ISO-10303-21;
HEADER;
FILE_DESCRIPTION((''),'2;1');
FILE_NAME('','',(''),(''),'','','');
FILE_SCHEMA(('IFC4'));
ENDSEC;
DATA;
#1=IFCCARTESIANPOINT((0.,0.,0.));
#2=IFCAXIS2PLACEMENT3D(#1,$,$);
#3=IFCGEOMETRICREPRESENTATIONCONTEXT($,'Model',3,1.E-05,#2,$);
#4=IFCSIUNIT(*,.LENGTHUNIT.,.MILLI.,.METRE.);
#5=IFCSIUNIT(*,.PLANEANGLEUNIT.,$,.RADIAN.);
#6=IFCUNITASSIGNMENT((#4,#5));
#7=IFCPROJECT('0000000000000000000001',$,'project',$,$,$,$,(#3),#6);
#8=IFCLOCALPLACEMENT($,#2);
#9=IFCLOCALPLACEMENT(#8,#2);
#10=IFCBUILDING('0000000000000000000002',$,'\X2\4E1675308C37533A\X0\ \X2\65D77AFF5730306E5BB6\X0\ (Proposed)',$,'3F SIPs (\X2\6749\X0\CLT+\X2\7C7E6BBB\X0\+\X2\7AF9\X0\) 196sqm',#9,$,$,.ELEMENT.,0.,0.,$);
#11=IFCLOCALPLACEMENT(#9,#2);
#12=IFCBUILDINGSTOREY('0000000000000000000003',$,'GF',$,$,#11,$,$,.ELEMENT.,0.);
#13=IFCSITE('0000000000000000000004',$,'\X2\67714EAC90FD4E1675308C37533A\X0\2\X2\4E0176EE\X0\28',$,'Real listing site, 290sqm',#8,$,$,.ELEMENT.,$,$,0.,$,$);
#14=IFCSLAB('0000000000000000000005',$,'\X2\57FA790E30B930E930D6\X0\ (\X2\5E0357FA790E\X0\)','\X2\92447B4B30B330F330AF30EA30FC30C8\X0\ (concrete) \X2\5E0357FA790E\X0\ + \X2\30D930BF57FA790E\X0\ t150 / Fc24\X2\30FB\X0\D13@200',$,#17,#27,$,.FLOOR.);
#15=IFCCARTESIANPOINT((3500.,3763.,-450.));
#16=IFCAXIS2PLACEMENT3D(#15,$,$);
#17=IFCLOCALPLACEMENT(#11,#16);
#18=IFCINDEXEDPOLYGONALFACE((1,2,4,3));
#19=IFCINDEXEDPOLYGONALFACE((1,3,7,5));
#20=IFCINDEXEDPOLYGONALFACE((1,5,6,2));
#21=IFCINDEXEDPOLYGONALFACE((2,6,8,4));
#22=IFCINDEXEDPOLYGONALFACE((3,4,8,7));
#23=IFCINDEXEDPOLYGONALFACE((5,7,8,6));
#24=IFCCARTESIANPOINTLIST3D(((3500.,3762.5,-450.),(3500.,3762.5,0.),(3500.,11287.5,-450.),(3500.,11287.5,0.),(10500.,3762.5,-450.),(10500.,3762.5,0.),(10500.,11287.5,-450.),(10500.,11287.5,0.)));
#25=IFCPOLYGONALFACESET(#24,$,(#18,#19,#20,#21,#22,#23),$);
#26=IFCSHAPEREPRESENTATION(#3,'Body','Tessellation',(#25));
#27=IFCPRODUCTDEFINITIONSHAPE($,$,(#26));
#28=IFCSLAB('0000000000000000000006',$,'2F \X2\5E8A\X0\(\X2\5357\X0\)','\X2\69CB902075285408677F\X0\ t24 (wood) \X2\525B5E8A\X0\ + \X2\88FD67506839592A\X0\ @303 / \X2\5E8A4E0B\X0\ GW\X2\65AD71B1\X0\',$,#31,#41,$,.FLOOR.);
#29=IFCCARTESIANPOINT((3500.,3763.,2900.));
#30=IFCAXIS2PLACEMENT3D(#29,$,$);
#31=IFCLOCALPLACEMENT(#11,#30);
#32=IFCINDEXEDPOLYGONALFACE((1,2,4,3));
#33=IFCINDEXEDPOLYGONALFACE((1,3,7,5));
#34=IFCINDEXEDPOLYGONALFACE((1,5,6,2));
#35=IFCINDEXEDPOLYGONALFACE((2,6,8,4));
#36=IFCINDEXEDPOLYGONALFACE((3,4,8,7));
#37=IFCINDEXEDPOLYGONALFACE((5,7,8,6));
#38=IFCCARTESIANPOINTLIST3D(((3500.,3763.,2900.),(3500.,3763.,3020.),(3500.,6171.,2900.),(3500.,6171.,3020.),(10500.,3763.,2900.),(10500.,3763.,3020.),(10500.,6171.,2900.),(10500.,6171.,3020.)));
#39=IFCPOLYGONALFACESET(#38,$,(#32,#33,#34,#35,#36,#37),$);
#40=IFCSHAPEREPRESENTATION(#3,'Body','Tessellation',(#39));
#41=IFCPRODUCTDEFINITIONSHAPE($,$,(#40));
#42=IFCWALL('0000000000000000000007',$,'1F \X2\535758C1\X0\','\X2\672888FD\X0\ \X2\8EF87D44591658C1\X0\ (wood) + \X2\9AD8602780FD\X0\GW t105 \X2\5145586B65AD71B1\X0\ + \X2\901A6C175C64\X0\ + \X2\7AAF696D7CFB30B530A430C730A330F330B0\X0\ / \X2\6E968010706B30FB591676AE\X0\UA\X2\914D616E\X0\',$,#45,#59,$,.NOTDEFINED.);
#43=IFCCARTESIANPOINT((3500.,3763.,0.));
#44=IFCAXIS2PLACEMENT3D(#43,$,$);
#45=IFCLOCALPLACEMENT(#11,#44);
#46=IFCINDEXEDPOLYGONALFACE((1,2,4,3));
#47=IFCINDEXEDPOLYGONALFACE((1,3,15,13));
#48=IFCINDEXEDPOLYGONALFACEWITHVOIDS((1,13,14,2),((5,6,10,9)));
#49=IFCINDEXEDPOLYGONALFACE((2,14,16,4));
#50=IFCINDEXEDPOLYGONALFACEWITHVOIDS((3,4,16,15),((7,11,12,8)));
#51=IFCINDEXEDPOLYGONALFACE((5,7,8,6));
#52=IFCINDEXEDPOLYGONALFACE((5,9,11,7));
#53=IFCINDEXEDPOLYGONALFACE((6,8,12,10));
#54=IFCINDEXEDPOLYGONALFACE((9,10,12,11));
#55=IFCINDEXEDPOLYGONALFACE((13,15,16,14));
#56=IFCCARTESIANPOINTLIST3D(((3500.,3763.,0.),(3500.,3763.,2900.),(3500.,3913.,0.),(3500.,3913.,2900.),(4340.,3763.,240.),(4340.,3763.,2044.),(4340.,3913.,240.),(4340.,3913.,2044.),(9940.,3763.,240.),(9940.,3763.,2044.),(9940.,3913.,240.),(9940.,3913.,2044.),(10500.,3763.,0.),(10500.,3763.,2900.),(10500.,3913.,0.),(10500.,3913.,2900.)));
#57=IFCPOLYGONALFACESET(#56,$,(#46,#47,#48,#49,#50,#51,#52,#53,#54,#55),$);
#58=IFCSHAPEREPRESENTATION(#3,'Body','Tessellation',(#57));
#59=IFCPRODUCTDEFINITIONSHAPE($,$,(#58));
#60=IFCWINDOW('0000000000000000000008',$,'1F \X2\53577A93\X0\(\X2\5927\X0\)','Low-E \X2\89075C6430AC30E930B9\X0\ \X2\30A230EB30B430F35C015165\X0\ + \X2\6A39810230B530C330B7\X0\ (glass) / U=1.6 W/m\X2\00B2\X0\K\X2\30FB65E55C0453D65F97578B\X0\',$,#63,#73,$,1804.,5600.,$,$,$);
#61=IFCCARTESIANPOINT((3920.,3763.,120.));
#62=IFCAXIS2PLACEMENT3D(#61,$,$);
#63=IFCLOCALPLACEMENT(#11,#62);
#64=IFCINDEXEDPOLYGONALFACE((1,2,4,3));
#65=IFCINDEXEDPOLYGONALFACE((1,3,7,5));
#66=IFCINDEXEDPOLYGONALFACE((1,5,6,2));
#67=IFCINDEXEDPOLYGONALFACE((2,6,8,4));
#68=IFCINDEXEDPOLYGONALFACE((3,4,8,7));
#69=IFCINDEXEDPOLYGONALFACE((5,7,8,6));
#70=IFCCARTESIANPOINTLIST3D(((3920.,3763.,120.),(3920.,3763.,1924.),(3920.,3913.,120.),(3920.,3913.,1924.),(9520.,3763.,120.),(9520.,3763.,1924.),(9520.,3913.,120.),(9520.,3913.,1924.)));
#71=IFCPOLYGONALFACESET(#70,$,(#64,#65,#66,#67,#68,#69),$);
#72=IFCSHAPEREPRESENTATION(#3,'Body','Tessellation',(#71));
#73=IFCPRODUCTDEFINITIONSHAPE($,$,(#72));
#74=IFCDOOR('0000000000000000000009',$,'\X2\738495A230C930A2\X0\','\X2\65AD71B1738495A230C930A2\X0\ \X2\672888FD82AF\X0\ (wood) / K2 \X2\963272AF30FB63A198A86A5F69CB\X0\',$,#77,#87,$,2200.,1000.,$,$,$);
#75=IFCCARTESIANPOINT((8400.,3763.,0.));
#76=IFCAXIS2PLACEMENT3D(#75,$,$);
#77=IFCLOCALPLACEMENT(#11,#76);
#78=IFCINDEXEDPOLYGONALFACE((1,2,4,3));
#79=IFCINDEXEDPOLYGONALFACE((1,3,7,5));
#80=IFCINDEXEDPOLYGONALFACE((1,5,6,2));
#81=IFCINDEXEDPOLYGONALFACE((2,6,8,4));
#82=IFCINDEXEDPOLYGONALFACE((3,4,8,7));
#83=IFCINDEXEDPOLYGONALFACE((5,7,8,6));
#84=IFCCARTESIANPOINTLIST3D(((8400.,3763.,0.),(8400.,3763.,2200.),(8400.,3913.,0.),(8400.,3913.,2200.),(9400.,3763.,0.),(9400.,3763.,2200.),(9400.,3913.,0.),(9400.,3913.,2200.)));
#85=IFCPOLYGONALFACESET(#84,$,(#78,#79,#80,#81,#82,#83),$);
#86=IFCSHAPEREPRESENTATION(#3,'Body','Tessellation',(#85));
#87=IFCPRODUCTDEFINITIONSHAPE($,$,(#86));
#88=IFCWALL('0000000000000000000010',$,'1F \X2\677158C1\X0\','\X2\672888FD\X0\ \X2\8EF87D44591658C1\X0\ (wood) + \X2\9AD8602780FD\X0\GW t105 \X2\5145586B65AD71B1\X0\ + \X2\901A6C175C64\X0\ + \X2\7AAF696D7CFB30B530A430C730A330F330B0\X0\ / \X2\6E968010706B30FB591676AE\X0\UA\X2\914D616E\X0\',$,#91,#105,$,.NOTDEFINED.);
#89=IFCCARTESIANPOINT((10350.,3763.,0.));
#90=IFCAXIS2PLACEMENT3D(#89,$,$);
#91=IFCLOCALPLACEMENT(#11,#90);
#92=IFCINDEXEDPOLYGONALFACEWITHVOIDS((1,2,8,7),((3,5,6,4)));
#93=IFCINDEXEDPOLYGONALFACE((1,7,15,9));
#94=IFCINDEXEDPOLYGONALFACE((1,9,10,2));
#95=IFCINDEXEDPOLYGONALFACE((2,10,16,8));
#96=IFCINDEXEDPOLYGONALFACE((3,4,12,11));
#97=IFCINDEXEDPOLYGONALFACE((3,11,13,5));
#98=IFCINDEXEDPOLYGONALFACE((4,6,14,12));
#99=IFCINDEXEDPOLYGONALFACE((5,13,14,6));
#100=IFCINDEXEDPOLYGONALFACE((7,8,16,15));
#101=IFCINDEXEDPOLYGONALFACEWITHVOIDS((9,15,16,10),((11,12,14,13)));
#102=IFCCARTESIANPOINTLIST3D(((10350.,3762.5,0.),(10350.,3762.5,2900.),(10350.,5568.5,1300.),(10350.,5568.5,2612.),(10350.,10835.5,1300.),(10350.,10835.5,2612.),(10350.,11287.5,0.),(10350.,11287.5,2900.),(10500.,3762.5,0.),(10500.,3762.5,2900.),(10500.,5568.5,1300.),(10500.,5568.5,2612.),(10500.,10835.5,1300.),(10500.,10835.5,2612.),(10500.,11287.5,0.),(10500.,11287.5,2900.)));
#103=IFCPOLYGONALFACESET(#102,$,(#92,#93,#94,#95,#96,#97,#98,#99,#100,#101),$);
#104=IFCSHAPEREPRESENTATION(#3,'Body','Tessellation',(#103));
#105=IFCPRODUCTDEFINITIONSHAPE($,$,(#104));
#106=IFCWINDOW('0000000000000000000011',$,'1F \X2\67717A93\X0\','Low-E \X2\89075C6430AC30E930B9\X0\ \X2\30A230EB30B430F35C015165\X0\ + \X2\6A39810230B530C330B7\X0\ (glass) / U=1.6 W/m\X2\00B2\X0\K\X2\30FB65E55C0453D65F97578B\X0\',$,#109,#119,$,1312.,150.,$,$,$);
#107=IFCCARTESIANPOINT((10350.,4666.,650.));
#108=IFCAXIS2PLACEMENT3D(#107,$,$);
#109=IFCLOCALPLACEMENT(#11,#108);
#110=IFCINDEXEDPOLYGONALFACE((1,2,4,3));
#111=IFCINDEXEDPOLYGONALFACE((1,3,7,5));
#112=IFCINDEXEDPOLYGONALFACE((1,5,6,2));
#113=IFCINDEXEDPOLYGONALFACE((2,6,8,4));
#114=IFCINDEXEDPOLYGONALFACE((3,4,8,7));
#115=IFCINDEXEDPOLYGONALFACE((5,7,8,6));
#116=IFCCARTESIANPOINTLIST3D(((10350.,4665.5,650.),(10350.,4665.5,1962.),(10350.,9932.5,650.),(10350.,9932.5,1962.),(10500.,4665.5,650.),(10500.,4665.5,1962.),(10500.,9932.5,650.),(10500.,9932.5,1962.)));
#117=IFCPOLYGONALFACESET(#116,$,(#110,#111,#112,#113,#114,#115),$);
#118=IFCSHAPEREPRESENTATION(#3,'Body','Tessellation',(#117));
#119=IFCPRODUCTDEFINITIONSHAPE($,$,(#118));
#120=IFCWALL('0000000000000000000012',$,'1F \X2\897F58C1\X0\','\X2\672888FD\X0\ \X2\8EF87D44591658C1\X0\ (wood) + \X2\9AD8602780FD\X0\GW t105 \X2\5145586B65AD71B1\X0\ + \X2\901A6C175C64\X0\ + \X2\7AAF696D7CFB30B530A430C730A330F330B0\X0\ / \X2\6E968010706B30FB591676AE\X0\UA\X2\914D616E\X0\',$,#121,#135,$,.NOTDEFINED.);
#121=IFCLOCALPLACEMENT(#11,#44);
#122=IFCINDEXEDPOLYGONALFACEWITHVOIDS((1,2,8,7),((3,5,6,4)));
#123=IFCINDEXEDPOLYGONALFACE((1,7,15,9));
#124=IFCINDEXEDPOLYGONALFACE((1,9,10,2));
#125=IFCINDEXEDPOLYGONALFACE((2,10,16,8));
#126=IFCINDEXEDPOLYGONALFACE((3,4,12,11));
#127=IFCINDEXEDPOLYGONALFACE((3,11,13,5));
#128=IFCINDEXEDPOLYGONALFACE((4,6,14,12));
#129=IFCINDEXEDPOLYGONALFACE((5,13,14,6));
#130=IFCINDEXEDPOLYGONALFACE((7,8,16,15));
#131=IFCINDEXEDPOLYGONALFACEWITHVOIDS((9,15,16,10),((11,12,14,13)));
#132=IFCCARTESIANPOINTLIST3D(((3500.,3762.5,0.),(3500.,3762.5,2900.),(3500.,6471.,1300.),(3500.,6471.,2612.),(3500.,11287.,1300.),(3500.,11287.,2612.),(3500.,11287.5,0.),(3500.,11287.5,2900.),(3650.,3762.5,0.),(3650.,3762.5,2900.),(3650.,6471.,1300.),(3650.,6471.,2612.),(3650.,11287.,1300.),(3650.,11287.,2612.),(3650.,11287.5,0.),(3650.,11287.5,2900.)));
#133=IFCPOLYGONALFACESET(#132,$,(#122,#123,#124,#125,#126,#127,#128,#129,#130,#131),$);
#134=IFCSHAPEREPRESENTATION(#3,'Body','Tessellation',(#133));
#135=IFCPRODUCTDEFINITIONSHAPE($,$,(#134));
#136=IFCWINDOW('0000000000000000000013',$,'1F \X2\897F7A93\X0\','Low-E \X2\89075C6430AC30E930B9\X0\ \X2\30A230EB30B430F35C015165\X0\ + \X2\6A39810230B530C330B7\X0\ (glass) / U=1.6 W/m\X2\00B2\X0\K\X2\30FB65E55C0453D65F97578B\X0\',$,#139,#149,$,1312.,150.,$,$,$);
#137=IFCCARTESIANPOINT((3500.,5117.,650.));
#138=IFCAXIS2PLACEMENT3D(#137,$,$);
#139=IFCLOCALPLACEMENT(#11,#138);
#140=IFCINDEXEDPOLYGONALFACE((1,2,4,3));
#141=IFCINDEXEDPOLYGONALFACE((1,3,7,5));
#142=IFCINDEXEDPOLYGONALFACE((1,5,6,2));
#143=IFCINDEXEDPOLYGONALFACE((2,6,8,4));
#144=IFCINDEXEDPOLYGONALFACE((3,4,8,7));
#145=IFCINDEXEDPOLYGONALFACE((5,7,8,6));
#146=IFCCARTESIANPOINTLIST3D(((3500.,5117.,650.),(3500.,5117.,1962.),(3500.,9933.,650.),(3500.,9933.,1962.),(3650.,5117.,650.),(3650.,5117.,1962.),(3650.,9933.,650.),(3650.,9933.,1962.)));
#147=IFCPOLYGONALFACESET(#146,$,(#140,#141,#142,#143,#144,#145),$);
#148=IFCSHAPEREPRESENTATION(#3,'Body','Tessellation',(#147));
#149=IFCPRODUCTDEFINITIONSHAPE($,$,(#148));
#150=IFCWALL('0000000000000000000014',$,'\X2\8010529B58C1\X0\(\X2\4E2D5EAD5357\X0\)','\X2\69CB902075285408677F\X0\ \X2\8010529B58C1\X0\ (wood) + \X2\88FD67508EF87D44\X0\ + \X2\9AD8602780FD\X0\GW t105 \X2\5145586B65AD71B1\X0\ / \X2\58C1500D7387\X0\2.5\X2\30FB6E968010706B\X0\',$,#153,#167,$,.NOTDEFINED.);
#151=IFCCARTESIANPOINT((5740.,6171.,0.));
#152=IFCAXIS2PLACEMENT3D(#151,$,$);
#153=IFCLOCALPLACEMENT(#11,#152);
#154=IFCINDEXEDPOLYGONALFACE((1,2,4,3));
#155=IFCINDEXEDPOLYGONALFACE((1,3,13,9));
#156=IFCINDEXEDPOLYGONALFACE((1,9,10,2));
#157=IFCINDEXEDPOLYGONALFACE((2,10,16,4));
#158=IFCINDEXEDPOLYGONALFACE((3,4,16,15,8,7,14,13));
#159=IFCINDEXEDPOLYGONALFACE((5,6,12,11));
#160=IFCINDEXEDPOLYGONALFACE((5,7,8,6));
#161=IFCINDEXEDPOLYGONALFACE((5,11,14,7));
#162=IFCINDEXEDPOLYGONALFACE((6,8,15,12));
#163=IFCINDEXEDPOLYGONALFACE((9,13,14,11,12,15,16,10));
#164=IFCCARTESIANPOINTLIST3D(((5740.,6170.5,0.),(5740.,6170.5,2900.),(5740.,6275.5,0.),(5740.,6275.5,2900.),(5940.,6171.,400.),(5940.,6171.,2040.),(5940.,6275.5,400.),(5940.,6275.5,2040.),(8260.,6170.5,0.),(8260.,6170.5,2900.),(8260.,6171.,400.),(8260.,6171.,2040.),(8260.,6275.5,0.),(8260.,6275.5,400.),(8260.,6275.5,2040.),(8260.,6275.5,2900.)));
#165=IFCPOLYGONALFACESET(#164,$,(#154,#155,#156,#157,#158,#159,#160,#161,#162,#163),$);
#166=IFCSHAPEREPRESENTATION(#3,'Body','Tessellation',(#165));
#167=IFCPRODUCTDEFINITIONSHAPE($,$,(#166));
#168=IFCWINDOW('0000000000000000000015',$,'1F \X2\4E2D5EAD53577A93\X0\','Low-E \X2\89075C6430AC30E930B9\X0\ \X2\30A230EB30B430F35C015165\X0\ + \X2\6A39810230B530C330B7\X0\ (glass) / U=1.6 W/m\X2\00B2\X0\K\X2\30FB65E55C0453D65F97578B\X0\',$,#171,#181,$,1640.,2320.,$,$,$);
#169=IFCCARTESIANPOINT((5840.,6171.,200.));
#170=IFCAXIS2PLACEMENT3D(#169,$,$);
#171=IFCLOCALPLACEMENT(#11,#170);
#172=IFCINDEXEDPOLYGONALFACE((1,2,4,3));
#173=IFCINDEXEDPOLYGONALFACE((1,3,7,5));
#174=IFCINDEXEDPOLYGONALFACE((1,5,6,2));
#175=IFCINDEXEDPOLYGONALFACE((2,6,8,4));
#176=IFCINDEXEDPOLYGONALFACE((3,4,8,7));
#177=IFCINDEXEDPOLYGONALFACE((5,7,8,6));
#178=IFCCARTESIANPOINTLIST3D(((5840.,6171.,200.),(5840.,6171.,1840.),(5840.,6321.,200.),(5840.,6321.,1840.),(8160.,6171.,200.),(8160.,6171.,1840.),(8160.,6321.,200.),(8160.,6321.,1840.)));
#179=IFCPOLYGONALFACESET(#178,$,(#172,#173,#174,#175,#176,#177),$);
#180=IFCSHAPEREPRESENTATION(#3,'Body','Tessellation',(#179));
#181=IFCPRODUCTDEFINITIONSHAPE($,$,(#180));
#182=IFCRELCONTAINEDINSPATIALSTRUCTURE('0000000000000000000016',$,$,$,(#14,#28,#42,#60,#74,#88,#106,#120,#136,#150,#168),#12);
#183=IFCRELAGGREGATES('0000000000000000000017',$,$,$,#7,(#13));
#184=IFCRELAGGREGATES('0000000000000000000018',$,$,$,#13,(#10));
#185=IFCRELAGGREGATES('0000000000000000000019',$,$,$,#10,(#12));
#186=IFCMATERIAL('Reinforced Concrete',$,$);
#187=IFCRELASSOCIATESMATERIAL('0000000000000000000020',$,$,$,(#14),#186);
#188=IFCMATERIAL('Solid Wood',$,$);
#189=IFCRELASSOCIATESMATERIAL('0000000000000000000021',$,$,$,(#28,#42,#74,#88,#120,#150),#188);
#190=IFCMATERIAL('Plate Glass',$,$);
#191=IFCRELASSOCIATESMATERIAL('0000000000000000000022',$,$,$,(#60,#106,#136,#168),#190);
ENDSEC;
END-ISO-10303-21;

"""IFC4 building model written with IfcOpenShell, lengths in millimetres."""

from ifc_helpers import new_model, si_unit, frame, frame_2d, origin, place, context, project, spatial, rectangle, extrude, material, element, fill, save


model = new_model("IFC4")

# Units and contexts
model_context = context("Model", 3, precision=1e-05, world=origin())
ifc_project = project(units=[si_unit("LENGTHUNIT", "METRE", prefix="MILLI"), si_unit("PLANEANGLEUNIT", "RADIAN")], contexts=[model_context])

# Site, building, storey
site_placement = place(None, origin())
site = spatial("IfcSite", under=ifc_project, at=site_placement, Name="東京都世田谷区2丁目28", ObjectType="Real listing site, 290sqm", CompositionType="ELEMENT", RefElevation=0.0)
building_placement = place(site_placement, origin())
building = spatial("IfcBuilding", under=site, at=building_placement, Name="世田谷区 旗竿地の家 (Proposed)", ObjectType="3F SIPs (杉CLT+籾殻+竹) 196sqm", CompositionType="ELEMENT", ElevationOfRefHeight=0.0, ElevationOfTerrain=0.0)
storey_placement = place(building_placement, origin())
storey = spatial("IfcBuildingStorey", under=building, at=storey_placement, Name="GF", CompositionType="ELEMENT", Elevation=0.0)

# Slabs
ifc_material_1 = material(Name="Reinforced Concrete")
slab_1_placement = place(storey_placement, frame((3500.0, 3763.0, -450.0)))
element("IfcSlab", 1, at=slab_1_placement, inside=storey, material=ifc_material_1, Name="基礎スラブ (布基礎)", Description="鉄筋コンクリート (concrete) 布基礎 + ベタ基礎 t150 / Fc24・D13@200", PredefinedType="FLOOR", context=model_context, shape_type="SweptSolid", body=[
    extrude(rectangle(XDim=7000.0, YDim=7525.0, at=frame_2d((3500.0, 3762.0))), frame((3500.0, 3763.0, -450.0)), (0.0, 0.0, 1.0), 450.0),
])
ifc_material_2 = material(Name="Solid Wood")
slab_2_placement = place(storey_placement, frame((3500.0, 3763.0, 2900.0)))
element("IfcSlab", 2, at=slab_2_placement, inside=storey, material=ifc_material_2, Name="2F 床(南)", Description="構造用合板 t24 (wood) 剛床 + 製材根太 @303 / 床下 GW断熱", PredefinedType="FLOOR", context=model_context, shape_type="SweptSolid", body=[
    extrude(rectangle(XDim=7000.0, YDim=2408.0, at=frame_2d((3500.0, 1204.0))), frame((3500.0, 3763.0, 2900.0)), (0.0, 0.0, 1.0), 120.0),
])

# Wall, openings, window, door
wall_1_placement = place(storey_placement, frame((3500.0, 3763.0, 0.0)))
wall_1 = element("IfcWall", 3, at=wall_1_placement, inside=storey, material=ifc_material_2, Name="1F 南壁", Description="木製 軸組外壁 (wood) + 高性能GW t105 充填断熱 + 通気層 + 窯業系サイディング / 準耐火・外皮UA配慮", PredefinedType="NOTDEFINED", context=model_context, shape_type="SweptSolid", body=[
    extrude(rectangle(XDim=7000.0, YDim=150.0, at=frame_2d((3500.0, 75.0))), frame((3500.0, 3763.0, 0.0)), (0.0, 0.0, 1.0), 2900.0),
])
opening_1_placement = place(storey_placement, frame((3920.0, 3763.0, 120.0)))
opening_1 = element("IfcOpeningElement", 4, at=opening_1_placement, cuts=wall_1, PredefinedType="NOTDEFINED", context=model_context, shape_type="SweptSolid", body=[
    extrude(rectangle(XDim=5600.0, YDim=150.0, at=frame_2d((2800.0, 75.0))), frame((3920.0, 3763.0, 120.0)), (0.0, 0.0, 1.0), 1804.0),
])
opening_2_placement = place(storey_placement, frame((8400.0, 3763.0, 0.0)))
opening_2 = element("IfcOpeningElement", 5, at=opening_2_placement, cuts=wall_1, PredefinedType="NOTDEFINED", context=model_context, shape_type="SweptSolid", body=[
    extrude(rectangle(XDim=1000.0, YDim=150.0, at=frame_2d((500.0, 75.0))), frame((8400.0, 3763.0, 0.0)), (0.0, 0.0, 1.0), 2200.0),
])
ifc_material_3 = material(Name="Plate Glass")
window_1_placement = place(storey_placement, frame((3920.0, 3763.0, 120.0)))
window_1 = element("IfcWindow", 6, at=window_1_placement, inside=storey, material=ifc_material_3, Name="1F 南窓(大)", Description="Low-E 複層ガラス アルゴン封入 + 樹脂サッシ (glass) / U=1.6 W/m²K・日射取得型", OverallHeight=1804.0, OverallWidth=5600.0, context=model_context, shape_type="SweptSolid", body=[
    extrude(rectangle(XDim=5600.0, YDim=150.0, at=frame_2d((2800.0, 75.0))), frame((3920.0, 3763.0, 120.0)), (0.0, 0.0, 1.0), 1804.0),
])
fill(opening_1, window_1)
door_placement = place(storey_placement, frame((8400.0, 3763.0, 0.0)))
door = element("IfcDoor", 7, at=door_placement, inside=storey, material=ifc_material_2, Name="玄関ドア", Description="断熱玄関ドア 木製芯 (wood) / K2 防犯・採風機構", OverallHeight=2200.0, OverallWidth=1000.0, context=model_context, shape_type="SweptSolid", body=[
    extrude(rectangle(XDim=1000.0, YDim=150.0, at=frame_2d((500.0, 75.0))), frame((8400.0, 3763.0, 0.0)), (0.0, 0.0, 1.0), 2200.0),
])
fill(opening_2, door)

# Walls, openings, windows
wall_2_placement = place(storey_placement, frame((10350.0, 3763.0, 0.0)))
wall_2 = element("IfcWall", 8, at=wall_2_placement, inside=storey, material=ifc_material_2, Name="1F 東壁", Description="木製 軸組外壁 (wood) + 高性能GW t105 充填断熱 + 通気層 + 窯業系サイディング / 準耐火・外皮UA配慮", PredefinedType="NOTDEFINED", context=model_context, shape_type="SweptSolid", body=[
    extrude(rectangle(XDim=150.0, YDim=7525.0, at=frame_2d((75.0, 3762.0))), frame((10350.0, 3763.0, 0.0)), (0.0, 0.0, 1.0), 2900.0),
])
opening_3_placement = place(storey_placement, frame((10350.0, 4666.0, 650.0)))
opening_3 = element("IfcOpeningElement", 9, at=opening_3_placement, cuts=wall_2, PredefinedType="NOTDEFINED", context=model_context, shape_type="SweptSolid", body=[
    extrude(rectangle(XDim=150.0, YDim=5267.0, at=frame_2d((75.0, 2633.0))), frame((10350.0, 4666.0, 650.0)), (0.0, 0.0, 1.0), 1312.0),
])
window_2_placement = place(storey_placement, frame((10350.0, 4666.0, 650.0)))
window_2 = element("IfcWindow", 10, at=window_2_placement, inside=storey, material=ifc_material_3, Name="1F 東窓", Description="Low-E 複層ガラス アルゴン封入 + 樹脂サッシ (glass) / U=1.6 W/m²K・日射取得型", OverallHeight=1312.0, OverallWidth=150.0, context=model_context, shape_type="SweptSolid", body=[
    extrude(rectangle(XDim=150.0, YDim=5267.0, at=frame_2d((75.0, 2633.0))), frame((10350.0, 4666.0, 650.0)), (0.0, 0.0, 1.0), 1312.0),
])
fill(opening_3, window_2)
wall_3_placement = place(storey_placement, frame((3500.0, 3763.0, 0.0)))
wall_3 = element("IfcWall", 11, at=wall_3_placement, inside=storey, material=ifc_material_2, Name="1F 西壁", Description="木製 軸組外壁 (wood) + 高性能GW t105 充填断熱 + 通気層 + 窯業系サイディング / 準耐火・外皮UA配慮", PredefinedType="NOTDEFINED", context=model_context, shape_type="SweptSolid", body=[
    extrude(rectangle(XDim=150.0, YDim=7525.0, at=frame_2d((75.0, 3762.0))), frame((3500.0, 3763.0, 0.0)), (0.0, 0.0, 1.0), 2900.0),
])
opening_4_placement = place(storey_placement, frame((3500.0, 5117.0, 650.0)))
opening_4 = element("IfcOpeningElement", 12, at=opening_4_placement, cuts=wall_3, PredefinedType="NOTDEFINED", context=model_context, shape_type="SweptSolid", body=[
    extrude(rectangle(XDim=150.0, YDim=4816.0, at=frame_2d((75.0, 2408.0))), frame((3500.0, 5117.0, 650.0)), (0.0, 0.0, 1.0), 1312.0),
])
window_3_placement = place(storey_placement, frame((3500.0, 5117.0, 650.0)))
window_3 = element("IfcWindow", 13, at=window_3_placement, inside=storey, material=ifc_material_3, Name="1F 西窓", Description="Low-E 複層ガラス アルゴン封入 + 樹脂サッシ (glass) / U=1.6 W/m²K・日射取得型", OverallHeight=1312.0, OverallWidth=150.0, context=model_context, shape_type="SweptSolid", body=[
    extrude(rectangle(XDim=150.0, YDim=4816.0, at=frame_2d((75.0, 2408.0))), frame((3500.0, 5117.0, 650.0)), (0.0, 0.0, 1.0), 1312.0),
])
fill(opening_4, window_3)
wall_4_placement = place(storey_placement, frame((5740.0, 6171.0, 0.0)))
wall_4 = element("IfcWall", 14, at=wall_4_placement, inside=storey, material=ifc_material_2, Name="耐力壁(中庭南)", Description="構造用合板 耐力壁 (wood) + 製材軸組 + 高性能GW t105 充填断熱 / 壁倍率2.5・準耐火", PredefinedType="NOTDEFINED", context=model_context, shape_type="SweptSolid", body=[
    extrude(rectangle(XDim=2520.0, YDim=105.0, at=frame_2d((1260.0, 52.0))), frame((5740.0, 6171.0, 0.0)), (0.0, 0.0, 1.0), 2900.0),
])
opening_5_placement = place(storey_placement, frame((5840.0, 6171.0, 200.0)))
opening_5 = element("IfcOpeningElement", 15, at=opening_5_placement, cuts=wall_4, PredefinedType="NOTDEFINED", context=model_context, shape_type="SweptSolid", body=[
    extrude(rectangle(XDim=2320.0, YDim=150.0, at=frame_2d((1160.0, 75.0))), frame((5840.0, 6171.0, 200.0)), (0.0, 0.0, 1.0), 1640.0),
])
window_4_placement = place(storey_placement, frame((5840.0, 6171.0, 200.0)))
window_4 = element("IfcWindow", 16, at=window_4_placement, inside=storey, material=ifc_material_3, Name="1F 中庭南窓", Description="Low-E 複層ガラス アルゴン封入 + 樹脂サッシ (glass) / U=1.6 W/m²K・日射取得型", OverallHeight=1640.0, OverallWidth=2320.0, context=model_context, shape_type="SweptSolid", body=[
    extrude(rectangle(XDim=2320.0, YDim=150.0, at=frame_2d((1160.0, 75.0))), frame((5840.0, 6171.0, 200.0)), (0.0, 0.0, 1.0), 1640.0),
])
fill(opening_5, window_4)

save(model, "model.ifc")
